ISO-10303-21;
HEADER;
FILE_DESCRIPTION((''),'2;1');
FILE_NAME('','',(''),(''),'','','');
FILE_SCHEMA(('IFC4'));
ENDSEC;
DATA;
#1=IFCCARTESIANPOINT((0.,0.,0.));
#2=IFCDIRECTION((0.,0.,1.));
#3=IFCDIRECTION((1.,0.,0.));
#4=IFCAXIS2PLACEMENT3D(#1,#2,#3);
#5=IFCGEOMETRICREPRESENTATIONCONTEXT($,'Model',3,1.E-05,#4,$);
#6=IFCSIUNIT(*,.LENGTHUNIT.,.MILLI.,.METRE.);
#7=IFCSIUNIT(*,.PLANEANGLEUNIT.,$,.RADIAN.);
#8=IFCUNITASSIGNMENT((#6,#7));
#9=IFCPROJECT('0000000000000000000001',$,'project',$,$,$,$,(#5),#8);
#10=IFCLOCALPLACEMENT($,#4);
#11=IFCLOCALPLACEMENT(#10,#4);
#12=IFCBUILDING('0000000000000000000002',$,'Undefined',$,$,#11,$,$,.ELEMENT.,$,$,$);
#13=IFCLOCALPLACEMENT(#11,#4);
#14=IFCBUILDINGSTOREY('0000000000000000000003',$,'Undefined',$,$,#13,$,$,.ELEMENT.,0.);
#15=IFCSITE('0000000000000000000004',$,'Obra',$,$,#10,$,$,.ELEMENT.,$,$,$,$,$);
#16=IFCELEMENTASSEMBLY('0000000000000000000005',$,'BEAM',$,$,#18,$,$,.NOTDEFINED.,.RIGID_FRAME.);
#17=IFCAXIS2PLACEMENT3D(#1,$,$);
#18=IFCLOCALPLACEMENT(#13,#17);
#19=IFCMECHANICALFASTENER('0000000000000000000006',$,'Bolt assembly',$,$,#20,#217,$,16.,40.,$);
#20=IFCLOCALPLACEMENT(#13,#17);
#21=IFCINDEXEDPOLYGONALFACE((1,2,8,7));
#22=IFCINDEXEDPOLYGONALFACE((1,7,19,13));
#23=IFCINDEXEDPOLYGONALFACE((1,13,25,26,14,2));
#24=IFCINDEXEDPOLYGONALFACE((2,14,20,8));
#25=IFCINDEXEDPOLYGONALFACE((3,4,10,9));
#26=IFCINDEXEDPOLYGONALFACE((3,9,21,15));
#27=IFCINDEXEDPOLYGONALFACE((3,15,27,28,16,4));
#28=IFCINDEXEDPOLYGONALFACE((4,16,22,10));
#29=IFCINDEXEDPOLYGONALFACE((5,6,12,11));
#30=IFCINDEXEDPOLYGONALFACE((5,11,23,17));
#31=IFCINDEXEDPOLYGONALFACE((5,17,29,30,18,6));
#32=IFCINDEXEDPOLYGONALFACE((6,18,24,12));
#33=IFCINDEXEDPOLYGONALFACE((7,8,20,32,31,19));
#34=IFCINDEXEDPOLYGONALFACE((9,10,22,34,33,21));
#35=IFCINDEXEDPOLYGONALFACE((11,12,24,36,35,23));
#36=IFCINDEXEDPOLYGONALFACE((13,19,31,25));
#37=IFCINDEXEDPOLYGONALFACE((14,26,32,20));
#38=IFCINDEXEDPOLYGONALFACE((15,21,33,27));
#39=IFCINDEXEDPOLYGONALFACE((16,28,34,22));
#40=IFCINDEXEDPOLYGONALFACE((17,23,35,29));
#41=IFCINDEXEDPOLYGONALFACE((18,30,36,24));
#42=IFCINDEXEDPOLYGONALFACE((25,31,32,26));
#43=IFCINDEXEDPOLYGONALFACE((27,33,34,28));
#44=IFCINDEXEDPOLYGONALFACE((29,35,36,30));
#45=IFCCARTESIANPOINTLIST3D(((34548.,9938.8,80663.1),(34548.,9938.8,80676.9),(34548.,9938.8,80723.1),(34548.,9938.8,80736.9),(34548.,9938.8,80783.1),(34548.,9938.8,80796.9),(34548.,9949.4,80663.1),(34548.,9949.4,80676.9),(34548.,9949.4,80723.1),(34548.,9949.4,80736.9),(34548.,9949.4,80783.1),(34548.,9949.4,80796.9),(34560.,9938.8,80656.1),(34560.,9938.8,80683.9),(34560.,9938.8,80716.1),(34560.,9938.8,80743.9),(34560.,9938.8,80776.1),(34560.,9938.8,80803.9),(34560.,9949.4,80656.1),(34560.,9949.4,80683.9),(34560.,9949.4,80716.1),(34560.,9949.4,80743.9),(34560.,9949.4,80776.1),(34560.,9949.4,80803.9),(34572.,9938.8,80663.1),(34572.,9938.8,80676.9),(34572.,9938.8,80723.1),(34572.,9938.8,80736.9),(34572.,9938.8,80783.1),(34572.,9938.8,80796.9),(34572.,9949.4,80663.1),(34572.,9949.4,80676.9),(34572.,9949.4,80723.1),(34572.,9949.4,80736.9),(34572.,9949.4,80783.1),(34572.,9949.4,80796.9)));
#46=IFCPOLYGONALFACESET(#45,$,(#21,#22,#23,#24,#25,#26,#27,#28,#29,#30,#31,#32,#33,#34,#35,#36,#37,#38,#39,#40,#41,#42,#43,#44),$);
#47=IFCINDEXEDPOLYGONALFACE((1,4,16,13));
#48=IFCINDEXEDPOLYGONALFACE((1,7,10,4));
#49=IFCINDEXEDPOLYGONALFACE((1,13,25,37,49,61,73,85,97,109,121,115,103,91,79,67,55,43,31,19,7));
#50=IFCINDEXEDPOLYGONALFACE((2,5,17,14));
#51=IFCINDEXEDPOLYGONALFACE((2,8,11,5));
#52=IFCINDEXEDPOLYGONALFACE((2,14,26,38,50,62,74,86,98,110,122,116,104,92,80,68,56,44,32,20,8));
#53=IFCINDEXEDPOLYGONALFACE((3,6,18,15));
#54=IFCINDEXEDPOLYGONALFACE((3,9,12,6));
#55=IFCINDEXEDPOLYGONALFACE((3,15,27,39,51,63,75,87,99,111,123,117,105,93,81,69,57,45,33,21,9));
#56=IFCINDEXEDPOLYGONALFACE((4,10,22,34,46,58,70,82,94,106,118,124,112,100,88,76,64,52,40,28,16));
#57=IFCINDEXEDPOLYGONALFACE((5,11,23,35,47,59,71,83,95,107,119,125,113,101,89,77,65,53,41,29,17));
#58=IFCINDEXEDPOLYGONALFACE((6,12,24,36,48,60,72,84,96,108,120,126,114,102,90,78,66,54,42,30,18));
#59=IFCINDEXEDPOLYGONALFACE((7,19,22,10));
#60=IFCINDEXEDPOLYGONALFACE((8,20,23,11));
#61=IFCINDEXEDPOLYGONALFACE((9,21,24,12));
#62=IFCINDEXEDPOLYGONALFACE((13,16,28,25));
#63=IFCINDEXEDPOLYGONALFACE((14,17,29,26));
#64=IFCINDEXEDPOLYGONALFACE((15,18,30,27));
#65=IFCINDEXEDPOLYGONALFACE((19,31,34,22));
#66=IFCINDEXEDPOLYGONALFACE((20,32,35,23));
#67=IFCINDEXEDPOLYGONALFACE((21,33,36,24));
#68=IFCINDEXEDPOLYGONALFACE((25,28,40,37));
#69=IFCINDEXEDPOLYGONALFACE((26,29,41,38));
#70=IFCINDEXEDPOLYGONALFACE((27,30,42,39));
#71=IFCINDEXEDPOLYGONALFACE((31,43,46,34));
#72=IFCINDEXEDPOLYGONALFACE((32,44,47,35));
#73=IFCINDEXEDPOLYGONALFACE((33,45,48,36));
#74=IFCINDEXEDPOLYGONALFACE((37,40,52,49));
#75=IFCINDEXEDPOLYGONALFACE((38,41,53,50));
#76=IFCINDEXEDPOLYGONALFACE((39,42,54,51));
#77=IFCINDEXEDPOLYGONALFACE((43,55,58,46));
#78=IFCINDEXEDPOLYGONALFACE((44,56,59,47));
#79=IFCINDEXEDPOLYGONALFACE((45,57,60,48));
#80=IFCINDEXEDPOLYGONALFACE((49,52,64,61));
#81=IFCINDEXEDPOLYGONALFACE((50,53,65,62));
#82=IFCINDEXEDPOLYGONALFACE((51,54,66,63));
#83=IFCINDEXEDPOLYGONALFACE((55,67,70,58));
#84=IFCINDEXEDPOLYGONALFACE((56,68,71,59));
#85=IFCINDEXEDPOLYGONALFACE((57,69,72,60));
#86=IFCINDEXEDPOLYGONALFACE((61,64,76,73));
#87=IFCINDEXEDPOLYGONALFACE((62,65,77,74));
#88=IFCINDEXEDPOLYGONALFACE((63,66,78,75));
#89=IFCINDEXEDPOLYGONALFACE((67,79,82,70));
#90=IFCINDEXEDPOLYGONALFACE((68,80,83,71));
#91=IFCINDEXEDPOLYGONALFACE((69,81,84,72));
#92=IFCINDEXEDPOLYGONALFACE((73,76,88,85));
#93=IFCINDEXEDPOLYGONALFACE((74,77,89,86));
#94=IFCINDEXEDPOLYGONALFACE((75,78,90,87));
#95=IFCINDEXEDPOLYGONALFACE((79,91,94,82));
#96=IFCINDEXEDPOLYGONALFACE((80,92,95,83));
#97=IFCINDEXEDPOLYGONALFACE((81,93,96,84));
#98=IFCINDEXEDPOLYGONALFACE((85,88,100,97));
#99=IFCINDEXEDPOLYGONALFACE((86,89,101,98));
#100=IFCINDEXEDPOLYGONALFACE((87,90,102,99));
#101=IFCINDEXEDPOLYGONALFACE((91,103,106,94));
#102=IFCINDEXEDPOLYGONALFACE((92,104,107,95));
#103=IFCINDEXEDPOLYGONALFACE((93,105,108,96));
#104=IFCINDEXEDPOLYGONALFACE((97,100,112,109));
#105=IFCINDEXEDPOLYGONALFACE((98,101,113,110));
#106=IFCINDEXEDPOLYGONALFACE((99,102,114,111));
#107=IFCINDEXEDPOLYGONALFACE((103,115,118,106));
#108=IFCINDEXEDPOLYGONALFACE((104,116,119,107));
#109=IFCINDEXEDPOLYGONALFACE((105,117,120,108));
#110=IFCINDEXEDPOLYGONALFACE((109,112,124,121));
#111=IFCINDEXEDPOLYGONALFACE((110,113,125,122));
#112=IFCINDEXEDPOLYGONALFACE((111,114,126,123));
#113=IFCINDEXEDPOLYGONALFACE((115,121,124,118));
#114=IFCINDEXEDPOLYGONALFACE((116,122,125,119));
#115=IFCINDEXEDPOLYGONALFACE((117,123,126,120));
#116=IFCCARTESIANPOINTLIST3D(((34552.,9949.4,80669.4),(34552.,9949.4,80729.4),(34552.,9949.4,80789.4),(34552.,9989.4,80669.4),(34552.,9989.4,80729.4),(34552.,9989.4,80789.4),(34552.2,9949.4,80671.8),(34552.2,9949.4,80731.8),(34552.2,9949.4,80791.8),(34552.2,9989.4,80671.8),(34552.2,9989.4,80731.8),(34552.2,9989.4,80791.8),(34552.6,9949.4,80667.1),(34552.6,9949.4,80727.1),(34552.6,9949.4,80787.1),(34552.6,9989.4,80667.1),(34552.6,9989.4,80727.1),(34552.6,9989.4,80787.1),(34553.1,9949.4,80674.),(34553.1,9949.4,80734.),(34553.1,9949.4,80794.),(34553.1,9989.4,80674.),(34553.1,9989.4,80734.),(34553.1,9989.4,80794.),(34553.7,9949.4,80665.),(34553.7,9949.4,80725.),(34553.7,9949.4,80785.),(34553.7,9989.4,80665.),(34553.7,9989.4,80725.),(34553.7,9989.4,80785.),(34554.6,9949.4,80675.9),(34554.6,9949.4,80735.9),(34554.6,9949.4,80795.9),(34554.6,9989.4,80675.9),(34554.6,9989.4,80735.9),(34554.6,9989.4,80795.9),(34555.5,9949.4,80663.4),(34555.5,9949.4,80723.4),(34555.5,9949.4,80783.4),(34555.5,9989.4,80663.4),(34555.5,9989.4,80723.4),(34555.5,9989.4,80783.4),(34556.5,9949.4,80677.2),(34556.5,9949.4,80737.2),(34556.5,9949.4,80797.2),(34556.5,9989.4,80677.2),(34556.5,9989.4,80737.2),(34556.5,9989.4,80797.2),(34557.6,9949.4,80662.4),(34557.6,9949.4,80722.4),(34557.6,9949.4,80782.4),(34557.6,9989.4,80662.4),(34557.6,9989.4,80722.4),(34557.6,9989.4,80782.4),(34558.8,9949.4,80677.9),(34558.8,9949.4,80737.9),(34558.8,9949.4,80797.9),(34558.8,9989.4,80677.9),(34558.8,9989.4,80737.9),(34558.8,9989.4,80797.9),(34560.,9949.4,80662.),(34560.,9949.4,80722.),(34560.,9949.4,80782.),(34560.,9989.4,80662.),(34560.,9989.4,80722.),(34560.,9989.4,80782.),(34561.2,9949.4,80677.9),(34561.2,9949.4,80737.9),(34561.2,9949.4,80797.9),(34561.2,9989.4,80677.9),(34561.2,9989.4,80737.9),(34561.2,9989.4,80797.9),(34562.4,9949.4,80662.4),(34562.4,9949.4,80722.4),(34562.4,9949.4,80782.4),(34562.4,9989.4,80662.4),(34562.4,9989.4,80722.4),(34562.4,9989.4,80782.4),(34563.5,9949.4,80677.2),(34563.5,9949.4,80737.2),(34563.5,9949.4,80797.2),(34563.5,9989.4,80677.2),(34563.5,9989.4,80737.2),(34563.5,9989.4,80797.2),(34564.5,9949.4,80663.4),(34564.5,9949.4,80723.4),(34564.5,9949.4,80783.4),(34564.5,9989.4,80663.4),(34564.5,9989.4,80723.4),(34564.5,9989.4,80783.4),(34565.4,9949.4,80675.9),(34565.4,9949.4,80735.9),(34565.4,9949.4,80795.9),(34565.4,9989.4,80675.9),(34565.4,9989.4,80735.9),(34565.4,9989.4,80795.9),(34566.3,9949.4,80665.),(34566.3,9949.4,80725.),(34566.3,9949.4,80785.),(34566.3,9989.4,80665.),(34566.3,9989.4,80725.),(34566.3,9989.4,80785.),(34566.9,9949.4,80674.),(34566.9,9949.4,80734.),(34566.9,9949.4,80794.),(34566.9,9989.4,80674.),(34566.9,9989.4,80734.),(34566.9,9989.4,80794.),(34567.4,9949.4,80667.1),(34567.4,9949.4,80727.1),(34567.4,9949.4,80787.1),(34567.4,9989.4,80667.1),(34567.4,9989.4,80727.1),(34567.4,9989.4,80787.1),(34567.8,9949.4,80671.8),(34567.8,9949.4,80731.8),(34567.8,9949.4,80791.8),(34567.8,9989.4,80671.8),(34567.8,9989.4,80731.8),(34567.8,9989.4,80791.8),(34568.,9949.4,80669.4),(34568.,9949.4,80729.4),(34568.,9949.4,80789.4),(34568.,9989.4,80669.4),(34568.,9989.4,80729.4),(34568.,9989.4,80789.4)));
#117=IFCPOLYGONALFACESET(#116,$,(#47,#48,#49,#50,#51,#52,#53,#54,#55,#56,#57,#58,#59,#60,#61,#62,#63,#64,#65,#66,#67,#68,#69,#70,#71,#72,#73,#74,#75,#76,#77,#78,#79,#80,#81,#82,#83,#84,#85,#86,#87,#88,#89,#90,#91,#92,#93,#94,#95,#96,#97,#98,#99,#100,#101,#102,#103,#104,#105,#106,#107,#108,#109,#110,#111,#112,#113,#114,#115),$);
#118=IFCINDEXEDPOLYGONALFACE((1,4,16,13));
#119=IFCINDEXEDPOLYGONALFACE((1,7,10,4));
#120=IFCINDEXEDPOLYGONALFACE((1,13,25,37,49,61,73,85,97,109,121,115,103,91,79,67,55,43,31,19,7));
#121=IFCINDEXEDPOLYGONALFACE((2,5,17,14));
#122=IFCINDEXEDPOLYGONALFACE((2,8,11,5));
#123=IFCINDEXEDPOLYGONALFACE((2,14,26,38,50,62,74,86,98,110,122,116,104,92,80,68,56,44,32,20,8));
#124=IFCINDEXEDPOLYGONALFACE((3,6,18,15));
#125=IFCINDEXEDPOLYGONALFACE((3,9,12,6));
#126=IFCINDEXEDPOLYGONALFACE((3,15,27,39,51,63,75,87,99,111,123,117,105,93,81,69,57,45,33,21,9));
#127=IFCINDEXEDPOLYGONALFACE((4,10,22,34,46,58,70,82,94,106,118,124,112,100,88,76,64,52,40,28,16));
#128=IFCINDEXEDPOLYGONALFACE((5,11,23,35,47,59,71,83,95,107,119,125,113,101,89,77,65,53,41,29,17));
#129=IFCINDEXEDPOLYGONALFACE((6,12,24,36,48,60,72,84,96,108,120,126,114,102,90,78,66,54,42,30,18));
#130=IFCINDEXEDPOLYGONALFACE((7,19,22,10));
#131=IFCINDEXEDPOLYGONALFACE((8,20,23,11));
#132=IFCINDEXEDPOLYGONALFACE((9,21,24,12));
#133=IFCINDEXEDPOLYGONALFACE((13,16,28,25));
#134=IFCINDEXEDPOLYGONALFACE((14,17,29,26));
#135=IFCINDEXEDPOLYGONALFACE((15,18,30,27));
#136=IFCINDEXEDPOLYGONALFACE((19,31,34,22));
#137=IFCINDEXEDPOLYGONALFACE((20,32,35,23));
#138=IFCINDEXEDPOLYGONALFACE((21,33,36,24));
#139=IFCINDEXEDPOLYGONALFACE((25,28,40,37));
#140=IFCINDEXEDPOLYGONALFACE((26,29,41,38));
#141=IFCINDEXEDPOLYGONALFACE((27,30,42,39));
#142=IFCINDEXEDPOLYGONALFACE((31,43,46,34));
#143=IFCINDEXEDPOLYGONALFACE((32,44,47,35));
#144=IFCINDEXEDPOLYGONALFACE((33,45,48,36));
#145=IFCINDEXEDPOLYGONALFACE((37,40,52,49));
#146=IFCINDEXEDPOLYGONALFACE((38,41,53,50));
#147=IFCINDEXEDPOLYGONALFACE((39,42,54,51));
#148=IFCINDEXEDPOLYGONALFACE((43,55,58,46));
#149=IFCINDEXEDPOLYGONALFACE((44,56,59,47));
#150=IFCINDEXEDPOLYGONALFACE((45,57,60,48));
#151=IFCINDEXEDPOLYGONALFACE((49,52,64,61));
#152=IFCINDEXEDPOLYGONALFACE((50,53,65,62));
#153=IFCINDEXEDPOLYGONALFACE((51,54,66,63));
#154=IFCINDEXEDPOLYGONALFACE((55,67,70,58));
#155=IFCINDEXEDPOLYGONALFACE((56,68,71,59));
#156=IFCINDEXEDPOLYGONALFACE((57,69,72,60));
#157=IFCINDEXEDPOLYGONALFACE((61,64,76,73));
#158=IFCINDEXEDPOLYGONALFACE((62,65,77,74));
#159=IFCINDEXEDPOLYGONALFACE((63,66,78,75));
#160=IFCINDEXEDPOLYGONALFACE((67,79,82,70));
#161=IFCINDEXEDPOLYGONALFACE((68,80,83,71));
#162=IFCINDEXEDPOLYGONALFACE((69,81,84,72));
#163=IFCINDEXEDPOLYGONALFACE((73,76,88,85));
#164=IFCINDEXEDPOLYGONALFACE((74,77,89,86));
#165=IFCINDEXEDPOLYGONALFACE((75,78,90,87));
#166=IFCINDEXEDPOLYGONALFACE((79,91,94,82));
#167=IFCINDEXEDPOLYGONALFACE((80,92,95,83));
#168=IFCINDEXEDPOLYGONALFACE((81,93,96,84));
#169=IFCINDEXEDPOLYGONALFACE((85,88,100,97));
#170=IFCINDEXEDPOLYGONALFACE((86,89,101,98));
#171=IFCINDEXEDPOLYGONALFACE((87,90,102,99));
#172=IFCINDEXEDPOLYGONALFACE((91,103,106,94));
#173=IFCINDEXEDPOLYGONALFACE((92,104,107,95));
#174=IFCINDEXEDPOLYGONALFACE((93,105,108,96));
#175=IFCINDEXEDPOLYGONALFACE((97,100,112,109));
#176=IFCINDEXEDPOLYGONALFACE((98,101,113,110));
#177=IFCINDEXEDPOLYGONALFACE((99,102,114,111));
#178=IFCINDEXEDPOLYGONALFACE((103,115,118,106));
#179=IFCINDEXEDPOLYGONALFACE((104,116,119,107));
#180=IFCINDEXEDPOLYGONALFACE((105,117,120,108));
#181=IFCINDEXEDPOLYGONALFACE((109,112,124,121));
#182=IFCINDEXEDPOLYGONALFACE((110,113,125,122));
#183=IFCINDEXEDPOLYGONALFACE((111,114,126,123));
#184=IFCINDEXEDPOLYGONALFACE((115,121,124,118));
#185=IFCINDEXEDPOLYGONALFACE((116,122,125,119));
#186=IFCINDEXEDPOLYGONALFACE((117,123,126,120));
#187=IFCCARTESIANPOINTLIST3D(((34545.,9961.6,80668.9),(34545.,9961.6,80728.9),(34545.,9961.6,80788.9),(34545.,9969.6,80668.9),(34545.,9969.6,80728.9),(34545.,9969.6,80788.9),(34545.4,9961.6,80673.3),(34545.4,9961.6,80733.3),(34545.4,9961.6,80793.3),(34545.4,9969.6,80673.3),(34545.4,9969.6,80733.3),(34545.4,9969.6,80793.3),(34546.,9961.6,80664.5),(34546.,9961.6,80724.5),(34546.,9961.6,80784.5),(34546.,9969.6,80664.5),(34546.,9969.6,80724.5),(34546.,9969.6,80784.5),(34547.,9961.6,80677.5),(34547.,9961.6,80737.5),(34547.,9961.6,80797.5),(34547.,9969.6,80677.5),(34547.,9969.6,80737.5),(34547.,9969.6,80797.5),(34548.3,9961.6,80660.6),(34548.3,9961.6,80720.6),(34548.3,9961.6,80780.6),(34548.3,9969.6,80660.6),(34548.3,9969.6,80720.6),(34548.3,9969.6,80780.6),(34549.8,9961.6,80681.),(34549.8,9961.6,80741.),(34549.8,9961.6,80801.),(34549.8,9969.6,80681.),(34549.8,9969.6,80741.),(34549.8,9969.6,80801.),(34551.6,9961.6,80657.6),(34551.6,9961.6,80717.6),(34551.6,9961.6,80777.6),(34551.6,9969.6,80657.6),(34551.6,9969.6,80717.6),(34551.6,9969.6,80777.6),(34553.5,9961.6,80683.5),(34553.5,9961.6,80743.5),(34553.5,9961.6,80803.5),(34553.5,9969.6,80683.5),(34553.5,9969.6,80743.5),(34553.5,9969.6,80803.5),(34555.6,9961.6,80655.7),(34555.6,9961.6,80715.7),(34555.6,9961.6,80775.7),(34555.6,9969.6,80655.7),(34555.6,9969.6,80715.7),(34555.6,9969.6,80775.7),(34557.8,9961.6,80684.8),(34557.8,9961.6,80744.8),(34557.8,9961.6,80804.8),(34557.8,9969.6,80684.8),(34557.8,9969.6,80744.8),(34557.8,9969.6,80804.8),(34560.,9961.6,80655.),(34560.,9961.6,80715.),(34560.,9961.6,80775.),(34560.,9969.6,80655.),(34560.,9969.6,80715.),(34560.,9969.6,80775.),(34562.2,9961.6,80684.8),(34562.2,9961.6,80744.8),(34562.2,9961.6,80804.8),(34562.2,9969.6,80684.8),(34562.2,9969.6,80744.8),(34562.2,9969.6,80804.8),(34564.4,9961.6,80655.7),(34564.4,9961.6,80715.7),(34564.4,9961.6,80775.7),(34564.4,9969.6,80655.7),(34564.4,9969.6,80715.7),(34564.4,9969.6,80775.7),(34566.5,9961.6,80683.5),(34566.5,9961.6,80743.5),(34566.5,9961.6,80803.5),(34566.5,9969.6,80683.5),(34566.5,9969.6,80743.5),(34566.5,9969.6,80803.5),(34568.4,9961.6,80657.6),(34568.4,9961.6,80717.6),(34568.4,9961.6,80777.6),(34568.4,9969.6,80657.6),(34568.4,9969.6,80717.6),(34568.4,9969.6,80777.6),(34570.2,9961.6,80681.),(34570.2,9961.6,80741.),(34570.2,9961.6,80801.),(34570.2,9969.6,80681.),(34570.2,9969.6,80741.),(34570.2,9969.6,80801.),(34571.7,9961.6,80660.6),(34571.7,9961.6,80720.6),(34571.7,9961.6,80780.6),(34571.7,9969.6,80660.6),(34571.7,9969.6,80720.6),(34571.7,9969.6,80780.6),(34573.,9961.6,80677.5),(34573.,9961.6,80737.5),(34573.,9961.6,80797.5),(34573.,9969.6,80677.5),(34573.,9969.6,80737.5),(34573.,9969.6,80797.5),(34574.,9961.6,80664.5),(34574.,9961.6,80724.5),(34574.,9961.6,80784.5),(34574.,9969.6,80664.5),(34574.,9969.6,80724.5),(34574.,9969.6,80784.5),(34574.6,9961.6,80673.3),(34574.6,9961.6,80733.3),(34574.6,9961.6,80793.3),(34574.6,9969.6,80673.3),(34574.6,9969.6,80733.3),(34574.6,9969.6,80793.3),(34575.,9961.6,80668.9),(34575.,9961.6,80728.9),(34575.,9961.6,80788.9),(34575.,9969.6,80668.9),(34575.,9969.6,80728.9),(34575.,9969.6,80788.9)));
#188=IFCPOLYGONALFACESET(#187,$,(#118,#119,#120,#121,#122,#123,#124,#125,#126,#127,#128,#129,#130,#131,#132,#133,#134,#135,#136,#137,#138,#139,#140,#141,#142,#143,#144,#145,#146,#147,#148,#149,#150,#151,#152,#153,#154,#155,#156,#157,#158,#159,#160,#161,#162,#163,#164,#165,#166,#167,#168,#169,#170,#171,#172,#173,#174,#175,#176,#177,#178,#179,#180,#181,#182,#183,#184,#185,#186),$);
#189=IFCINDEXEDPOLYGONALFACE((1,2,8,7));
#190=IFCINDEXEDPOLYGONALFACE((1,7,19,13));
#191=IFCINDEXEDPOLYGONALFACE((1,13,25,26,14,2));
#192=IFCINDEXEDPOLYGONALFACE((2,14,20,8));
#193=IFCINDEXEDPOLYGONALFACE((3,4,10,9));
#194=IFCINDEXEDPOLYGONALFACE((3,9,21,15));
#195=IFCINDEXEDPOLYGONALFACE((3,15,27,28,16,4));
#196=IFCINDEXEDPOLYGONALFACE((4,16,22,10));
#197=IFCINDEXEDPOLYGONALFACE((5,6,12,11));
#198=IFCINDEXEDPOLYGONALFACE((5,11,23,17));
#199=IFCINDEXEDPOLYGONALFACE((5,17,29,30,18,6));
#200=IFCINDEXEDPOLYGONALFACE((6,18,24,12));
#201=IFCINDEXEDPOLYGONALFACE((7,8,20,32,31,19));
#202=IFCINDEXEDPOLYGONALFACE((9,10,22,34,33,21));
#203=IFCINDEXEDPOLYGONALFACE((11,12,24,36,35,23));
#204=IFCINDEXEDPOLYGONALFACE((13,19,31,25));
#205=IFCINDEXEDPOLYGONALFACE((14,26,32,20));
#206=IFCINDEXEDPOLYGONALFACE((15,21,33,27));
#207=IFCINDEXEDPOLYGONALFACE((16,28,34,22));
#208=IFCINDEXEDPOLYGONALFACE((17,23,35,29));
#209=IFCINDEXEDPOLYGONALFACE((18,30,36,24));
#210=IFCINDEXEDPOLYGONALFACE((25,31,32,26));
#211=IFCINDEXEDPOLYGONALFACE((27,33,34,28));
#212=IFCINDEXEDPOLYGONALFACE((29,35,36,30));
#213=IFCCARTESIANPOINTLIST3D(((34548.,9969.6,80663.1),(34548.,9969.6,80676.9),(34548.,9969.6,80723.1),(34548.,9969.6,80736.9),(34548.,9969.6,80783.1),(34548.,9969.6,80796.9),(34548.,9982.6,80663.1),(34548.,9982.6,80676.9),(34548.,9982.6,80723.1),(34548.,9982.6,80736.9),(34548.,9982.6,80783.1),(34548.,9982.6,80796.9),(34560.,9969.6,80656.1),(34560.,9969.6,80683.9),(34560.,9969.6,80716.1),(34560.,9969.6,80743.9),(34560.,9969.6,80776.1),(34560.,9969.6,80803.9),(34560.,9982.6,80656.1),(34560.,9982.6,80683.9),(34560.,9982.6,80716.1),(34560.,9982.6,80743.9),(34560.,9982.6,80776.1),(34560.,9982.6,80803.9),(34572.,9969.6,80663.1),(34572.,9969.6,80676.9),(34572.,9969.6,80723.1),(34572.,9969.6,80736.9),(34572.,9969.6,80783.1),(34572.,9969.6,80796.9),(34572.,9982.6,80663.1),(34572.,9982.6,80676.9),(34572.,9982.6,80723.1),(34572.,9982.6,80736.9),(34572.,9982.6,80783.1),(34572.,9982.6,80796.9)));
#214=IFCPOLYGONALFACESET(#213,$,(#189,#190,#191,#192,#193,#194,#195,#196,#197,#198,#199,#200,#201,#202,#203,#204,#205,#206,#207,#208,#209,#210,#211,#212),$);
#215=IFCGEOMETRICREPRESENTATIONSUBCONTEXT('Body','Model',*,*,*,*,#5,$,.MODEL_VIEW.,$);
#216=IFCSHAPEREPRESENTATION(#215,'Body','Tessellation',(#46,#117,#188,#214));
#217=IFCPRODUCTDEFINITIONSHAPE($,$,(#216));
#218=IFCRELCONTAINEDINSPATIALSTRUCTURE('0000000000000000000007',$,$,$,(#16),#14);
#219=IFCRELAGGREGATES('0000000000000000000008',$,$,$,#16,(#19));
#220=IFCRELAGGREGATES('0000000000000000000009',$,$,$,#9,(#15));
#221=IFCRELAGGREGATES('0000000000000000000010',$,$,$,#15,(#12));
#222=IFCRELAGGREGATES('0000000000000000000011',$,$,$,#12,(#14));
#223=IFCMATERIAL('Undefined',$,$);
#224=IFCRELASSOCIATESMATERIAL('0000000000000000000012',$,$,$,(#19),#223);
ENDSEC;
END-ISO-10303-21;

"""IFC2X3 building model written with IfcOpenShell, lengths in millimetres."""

from ifc_helpers import new_model, si_unit, frame, origin_with_axes, origin_2d_with_axis, place, context, subcontext, project, spatial, polyline, circle, outline, extrude, source, transform, mapped, material, element, aggregate, save


model = new_model("IFC2X3")

# Units and contexts
model_context = context("Model", 3, precision=1e-05, world=origin_with_axes())
body_context = subcontext(model_context, "Body", "Model", "MODEL_VIEW")
ifc_project = project(units=[si_unit("LENGTHUNIT", "METRE", prefix="MILLI"), si_unit("PLANEANGLEUNIT", "RADIAN")], contexts=[model_context])

# Site, building, storey
site_placement = place(None, origin_with_axes())
site = spatial("IfcSite", under=ifc_project, at=site_placement, Name="Obra", CompositionType="ELEMENT")
building_placement = place(site_placement, origin_with_axes())
building = spatial("IfcBuilding", under=site, at=building_placement, Name="Undefined", CompositionType="ELEMENT")
storey_placement = place(building_placement, origin_with_axes())
storey = spatial("IfcBuildingStorey", under=building, at=storey_placement, Name="Undefined", CompositionType="ELEMENT", Elevation=0.0)

# Shared definitions
ifc_material_1 = material(Name="Undefined")

# Element assembly, mechanical fastener
assembly_1_placement = place(storey_placement, origin_with_axes())
assembly_1 = element("IfcElementAssembly", 1, at=assembly_1_placement, inside=storey, Name="BEAM", AssemblyPlace="NOTDEFINED", PredefinedType="RIGID_FRAME")
shared_shape_1 = source(origin_with_axes(), body_context, "Body", "SweptSolid", [
    extrude(outline(polyline([(13.9, 0.0), (6.9, 12.0), (-6.9, 12.0), (-13.9, 0.0), (-6.9, -12.0), (6.9, -12.0), (13.9, 0.0)])), frame((0.0, -19.7, 0.0), z_axis=(0.0, 1.0, 0.0), x_axis=(1.0, 0.0, 0.0)), (0.0, 0.0, 1.0), 10.6),
    extrude(circle(Radius=8.0, at=origin_2d_with_axis()), frame((0.0, -9.1, 0.0), z_axis=(0.0, 1.0, 0.0), x_axis=(1.0, 0.0, 0.0)), (0.0, 0.0, 1.0), 40.0),
    extrude(circle(Radius=15.0, at=origin_2d_with_axis()), frame((0.0, 3.1, 0.0), z_axis=(0.0, 1.0, 0.0), x_axis=(1.0, 0.0, 0.0)), (0.0, 0.0, 1.0), 8.0),
    extrude(outline(polyline([(13.9, 0.0), (6.9, 12.0), (-6.9, 12.0), (-13.9, 0.0), (-6.9, -12.0), (6.9, -12.0), (13.9, 0.0)])), frame((0.0, 11.1, 0.0), z_axis=(0.0, 1.0, 0.0), x_axis=(1.0, 0.0, 0.0)), (0.0, 0.0, 1.0), 13.0),
])
mechanical_fastener_1_placement = place(assembly_1_placement, frame((34510.0, 9958.5, 80850.0), z_axis=(1.0, 0.0, 0.0), x_axis=(0.0, 0.0, -1.0)))
mechanical_fastener_1 = element("IfcMechanicalFastener", 2, at=mechanical_fastener_1_placement, material=ifc_material_1, Name="Bolt assembly", NominalDiameter=16.0, NominalLength=40.0, context=body_context, shape_type="MappedRepresentation", body=[
    mapped(shared_shape_1, transform((60.0, 0.0, 50.0))),
    mapped(shared_shape_1, transform((120.0, 0.0, 50.0))),
    mapped(shared_shape_1, transform((180.0, 0.0, 50.0))),
])
aggregate(assembly_1, [mechanical_fastener_1])

save(model, "model.ifc")
